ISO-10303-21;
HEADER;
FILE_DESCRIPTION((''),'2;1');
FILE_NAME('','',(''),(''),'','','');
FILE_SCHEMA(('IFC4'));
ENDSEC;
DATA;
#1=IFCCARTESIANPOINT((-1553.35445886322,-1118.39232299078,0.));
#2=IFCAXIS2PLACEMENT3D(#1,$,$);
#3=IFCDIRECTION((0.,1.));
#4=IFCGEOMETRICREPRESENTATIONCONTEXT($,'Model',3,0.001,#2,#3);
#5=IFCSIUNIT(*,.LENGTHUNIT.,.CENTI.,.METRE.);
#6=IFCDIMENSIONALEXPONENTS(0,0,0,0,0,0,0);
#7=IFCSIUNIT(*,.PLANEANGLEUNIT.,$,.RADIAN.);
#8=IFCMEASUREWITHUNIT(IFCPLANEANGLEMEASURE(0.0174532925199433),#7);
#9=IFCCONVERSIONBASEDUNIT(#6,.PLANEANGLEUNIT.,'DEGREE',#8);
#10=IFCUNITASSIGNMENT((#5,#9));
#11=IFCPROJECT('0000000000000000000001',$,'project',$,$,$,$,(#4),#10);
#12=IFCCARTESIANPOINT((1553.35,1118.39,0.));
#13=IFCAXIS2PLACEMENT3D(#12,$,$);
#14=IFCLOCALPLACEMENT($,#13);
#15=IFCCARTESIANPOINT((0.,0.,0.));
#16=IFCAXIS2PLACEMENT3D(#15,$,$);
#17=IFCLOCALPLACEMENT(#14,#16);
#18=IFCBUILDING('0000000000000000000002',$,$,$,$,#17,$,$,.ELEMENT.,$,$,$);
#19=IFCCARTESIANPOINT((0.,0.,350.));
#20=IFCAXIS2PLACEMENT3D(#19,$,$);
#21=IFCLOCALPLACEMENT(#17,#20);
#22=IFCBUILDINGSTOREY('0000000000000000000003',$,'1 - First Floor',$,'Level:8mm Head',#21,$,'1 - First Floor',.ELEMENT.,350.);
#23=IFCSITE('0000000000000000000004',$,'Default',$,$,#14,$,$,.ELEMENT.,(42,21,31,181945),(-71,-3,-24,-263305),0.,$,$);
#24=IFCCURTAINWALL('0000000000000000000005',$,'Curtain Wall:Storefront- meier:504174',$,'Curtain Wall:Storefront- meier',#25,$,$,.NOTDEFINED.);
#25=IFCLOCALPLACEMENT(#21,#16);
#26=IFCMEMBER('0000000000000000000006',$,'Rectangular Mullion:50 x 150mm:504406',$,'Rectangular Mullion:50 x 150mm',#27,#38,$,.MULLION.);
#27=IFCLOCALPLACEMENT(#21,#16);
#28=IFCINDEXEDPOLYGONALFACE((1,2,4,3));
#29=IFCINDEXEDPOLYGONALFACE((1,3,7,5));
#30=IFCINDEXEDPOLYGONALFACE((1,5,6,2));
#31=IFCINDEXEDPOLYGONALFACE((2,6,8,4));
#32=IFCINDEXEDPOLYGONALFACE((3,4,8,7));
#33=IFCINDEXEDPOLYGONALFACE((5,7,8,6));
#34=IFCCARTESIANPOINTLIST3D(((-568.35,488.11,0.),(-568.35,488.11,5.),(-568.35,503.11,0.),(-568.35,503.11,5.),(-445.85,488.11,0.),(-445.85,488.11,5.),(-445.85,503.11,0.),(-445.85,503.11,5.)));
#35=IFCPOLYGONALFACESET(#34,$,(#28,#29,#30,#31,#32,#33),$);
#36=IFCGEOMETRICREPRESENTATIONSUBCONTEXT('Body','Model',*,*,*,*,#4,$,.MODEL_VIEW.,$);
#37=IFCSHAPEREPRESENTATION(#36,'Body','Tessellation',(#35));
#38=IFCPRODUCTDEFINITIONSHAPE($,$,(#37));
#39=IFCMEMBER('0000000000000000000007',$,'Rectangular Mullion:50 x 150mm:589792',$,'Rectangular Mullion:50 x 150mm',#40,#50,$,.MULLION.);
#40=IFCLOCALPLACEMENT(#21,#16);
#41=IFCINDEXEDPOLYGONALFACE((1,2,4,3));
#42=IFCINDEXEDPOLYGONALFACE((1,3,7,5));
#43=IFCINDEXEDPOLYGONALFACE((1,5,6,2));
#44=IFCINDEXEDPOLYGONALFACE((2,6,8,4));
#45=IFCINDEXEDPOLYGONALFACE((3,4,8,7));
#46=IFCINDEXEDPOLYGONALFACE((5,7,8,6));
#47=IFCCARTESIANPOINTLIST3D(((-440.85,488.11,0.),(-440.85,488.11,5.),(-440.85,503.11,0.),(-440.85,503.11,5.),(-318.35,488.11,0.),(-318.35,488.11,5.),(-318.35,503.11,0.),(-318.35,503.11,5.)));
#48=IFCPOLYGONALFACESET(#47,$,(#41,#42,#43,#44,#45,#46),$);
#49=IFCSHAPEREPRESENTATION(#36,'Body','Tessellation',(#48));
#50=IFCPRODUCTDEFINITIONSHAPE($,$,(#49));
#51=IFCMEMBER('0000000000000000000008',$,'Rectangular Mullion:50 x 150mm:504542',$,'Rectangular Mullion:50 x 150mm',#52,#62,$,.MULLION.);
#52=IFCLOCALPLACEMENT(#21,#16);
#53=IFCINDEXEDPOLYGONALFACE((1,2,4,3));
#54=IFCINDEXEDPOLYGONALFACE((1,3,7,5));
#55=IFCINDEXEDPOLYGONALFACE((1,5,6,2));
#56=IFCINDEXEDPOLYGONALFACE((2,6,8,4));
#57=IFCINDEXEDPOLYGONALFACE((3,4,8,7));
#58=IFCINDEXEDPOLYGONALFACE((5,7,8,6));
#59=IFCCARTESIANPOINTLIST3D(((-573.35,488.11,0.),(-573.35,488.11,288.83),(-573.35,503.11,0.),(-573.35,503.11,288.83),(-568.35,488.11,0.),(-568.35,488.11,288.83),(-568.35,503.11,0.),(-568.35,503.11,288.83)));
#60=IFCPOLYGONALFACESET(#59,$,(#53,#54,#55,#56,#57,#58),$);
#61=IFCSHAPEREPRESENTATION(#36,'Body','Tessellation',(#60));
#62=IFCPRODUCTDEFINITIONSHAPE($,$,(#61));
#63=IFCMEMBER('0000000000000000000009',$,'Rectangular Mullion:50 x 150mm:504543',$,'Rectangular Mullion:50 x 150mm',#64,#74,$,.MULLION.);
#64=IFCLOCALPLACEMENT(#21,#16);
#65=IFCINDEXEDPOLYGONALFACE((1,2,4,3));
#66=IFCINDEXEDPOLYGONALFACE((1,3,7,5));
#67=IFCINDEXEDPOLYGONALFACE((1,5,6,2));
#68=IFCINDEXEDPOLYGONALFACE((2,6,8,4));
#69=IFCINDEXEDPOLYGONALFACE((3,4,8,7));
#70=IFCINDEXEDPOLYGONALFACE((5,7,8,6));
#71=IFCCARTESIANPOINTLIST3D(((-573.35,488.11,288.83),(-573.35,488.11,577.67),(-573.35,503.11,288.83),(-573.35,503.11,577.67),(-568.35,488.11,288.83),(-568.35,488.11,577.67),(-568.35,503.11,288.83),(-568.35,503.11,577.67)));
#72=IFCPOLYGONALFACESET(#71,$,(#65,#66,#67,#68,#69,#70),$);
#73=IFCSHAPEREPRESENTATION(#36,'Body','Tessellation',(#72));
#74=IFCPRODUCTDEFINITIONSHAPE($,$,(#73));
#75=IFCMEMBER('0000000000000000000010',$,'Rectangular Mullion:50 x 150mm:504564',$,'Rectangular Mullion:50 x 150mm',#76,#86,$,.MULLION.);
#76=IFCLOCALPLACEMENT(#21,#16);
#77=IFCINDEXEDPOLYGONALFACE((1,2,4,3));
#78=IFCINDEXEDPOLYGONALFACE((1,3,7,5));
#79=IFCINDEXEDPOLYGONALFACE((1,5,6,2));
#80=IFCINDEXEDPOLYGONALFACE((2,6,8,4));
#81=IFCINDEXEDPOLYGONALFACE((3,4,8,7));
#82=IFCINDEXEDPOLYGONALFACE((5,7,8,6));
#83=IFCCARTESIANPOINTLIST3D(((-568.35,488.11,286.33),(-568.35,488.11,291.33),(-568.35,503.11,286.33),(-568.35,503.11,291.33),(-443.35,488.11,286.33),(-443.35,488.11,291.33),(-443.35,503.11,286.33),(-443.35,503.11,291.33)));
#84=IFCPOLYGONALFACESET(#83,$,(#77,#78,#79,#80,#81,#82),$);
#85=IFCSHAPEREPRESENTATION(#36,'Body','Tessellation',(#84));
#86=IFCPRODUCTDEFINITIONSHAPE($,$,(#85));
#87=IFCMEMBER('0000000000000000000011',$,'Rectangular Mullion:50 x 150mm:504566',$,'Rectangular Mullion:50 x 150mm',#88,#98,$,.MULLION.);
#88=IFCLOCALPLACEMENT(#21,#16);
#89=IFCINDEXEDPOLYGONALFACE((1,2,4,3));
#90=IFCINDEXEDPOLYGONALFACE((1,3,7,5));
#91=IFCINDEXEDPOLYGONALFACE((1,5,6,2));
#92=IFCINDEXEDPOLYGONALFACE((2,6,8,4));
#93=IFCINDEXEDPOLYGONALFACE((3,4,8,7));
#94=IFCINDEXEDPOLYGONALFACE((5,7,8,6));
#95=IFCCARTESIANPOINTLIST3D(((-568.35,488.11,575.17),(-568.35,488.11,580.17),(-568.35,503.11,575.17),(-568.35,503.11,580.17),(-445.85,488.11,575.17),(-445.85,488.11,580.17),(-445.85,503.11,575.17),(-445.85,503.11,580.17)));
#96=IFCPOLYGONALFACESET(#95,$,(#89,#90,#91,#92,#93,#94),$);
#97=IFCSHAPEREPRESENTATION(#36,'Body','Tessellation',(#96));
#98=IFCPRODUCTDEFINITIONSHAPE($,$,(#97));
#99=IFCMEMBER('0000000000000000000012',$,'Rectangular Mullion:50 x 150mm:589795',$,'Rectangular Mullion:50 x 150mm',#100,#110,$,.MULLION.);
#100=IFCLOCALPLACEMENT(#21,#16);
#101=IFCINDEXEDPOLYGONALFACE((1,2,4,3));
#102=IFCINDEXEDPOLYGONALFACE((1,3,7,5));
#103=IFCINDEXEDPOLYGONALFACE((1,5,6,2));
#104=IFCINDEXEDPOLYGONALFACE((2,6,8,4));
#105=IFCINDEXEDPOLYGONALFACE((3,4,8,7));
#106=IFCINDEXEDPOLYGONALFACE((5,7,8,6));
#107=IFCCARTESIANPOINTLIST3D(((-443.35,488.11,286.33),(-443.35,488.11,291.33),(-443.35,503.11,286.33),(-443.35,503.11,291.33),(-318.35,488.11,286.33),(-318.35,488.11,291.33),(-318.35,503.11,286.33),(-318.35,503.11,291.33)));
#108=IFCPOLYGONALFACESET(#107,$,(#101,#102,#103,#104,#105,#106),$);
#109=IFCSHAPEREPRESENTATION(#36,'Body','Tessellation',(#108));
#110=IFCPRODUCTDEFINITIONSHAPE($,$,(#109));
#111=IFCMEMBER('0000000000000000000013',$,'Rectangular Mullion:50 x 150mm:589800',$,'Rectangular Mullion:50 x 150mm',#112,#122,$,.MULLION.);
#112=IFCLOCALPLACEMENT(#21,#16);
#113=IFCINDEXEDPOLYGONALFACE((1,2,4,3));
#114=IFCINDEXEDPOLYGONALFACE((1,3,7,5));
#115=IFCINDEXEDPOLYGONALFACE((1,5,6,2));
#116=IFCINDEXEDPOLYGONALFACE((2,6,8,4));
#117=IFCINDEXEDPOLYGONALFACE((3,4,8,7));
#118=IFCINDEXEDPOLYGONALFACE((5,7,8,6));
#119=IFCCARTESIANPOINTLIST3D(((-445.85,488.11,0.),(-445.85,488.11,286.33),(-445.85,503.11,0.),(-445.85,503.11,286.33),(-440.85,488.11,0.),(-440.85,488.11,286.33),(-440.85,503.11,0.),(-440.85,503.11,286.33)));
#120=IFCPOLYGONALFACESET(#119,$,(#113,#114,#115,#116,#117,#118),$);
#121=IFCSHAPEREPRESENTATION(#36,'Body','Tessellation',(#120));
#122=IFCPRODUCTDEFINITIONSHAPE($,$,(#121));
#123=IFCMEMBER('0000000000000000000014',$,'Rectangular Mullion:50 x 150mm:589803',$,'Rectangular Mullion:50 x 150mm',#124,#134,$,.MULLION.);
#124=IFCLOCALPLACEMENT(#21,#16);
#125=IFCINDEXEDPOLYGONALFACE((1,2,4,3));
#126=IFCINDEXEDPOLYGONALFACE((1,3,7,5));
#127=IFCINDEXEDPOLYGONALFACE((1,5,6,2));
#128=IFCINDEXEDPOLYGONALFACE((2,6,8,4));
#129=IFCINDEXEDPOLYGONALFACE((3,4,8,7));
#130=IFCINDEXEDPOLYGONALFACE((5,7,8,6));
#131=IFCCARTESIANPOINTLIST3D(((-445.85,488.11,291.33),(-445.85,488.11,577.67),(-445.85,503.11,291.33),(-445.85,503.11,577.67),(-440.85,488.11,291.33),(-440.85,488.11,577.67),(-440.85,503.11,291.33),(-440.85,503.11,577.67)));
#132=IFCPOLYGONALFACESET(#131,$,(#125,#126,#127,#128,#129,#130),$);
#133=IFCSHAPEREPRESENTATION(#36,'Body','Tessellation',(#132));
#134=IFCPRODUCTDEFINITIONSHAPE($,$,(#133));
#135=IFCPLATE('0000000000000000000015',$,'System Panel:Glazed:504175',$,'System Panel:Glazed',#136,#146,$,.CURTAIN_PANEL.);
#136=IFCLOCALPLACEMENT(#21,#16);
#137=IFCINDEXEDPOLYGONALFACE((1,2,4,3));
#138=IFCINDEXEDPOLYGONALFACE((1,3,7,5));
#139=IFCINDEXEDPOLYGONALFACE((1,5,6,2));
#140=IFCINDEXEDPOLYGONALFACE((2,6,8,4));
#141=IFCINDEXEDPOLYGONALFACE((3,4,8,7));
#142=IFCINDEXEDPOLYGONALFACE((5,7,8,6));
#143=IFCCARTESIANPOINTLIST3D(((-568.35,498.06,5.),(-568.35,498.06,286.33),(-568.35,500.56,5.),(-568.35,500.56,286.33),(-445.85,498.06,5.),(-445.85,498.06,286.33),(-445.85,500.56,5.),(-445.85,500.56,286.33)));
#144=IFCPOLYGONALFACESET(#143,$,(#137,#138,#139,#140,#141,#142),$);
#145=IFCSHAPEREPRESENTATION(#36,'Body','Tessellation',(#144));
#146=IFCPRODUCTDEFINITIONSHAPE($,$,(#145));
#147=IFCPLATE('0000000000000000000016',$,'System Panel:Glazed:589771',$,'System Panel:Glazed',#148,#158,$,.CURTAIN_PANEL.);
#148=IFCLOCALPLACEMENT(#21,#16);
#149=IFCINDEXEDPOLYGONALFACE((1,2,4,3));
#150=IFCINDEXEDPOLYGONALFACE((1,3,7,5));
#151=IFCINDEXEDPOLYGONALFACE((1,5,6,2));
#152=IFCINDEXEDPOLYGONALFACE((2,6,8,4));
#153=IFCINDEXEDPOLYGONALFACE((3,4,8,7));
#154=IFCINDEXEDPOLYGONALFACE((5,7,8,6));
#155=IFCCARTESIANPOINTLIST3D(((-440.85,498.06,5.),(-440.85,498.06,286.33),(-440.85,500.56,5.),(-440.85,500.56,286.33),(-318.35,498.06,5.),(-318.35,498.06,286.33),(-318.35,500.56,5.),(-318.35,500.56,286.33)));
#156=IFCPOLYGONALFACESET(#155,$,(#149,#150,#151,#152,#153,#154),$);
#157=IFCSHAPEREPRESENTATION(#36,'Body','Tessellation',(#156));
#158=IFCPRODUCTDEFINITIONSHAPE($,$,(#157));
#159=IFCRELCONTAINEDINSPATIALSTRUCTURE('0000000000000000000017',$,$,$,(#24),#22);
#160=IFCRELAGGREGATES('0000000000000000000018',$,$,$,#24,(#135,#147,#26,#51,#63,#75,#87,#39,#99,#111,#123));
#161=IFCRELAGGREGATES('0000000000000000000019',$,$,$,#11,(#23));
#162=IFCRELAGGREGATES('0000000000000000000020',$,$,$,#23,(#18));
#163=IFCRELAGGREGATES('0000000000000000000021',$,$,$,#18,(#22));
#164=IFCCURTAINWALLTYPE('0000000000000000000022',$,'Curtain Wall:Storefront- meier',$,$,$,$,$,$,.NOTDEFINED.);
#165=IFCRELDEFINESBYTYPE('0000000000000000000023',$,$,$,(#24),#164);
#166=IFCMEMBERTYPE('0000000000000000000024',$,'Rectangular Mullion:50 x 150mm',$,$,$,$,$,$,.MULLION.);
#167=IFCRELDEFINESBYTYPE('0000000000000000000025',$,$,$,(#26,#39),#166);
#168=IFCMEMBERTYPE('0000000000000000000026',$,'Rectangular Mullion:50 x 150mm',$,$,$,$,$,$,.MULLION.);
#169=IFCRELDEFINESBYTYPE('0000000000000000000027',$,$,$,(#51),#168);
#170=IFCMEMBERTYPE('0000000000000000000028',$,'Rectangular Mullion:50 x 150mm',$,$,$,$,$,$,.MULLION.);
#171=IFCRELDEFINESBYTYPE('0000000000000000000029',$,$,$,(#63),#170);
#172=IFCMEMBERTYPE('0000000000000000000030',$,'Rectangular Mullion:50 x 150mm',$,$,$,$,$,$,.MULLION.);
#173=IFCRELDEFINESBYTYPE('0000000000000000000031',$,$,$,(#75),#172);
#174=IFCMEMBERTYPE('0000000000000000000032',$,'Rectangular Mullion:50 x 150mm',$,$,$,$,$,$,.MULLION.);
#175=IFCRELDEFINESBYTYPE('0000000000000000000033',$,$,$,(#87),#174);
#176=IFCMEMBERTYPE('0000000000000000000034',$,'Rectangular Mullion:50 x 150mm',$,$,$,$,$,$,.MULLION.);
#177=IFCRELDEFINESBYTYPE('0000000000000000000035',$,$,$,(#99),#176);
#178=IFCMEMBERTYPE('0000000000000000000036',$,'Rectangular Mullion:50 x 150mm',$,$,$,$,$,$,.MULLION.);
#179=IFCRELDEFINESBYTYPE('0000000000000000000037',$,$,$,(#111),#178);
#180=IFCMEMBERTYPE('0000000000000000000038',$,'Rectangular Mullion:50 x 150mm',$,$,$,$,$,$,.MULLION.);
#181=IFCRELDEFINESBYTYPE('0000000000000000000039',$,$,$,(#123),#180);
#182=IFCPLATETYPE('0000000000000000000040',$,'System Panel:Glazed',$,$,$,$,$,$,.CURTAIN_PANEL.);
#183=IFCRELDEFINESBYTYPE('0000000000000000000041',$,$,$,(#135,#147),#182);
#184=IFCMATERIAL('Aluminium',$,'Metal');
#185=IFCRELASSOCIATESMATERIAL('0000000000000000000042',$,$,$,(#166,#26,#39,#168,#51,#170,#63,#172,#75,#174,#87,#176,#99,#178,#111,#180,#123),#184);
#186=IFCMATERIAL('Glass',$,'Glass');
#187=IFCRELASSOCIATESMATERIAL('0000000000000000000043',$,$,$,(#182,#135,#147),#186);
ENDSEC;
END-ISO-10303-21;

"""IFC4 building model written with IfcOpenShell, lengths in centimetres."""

from ifc_helpers import new_model, entity, si_unit, converted_unit, direction, frame, origin, place, context, subcontext, project, spatial, indexed_curve, outline, extrude, source, transform, mapped, material, type_object, type_shapes, element, aggregate, save


model = new_model("IFC4")

# Units and contexts
model_context = context("Model", 3, precision=0.001, world=frame((-1553.35445886322, -1118.39232299078, 0.0)), true_north=direction((0.0, 1.0)))
body_context = subcontext(model_context, "Body", "Model", "MODEL_VIEW")
ifc_project = project(units=[si_unit("LENGTHUNIT", "METRE", prefix="CENTI"), converted_unit("PLANEANGLEUNIT", "DEGREE", entity("IfcPlaneAngleMeasure", 0.0174532925199433), si_unit("PLANEANGLEUNIT", "RADIAN"), dimensions=[0, 0, 0, 0, 0, 0, 0])], contexts=[model_context])

# Site, building, storey
site_placement = place(None, frame((1553.35, 1118.39, 0.0)))
site = spatial("IfcSite", under=ifc_project, at=site_placement, Name="Default", CompositionType="ELEMENT", RefLatitude=(42, 21, 31, 181945), RefLongitude=(-71, -3, -24, -263305), RefElevation=0.0)
building_placement = place(site_placement, origin())
building = spatial("IfcBuilding", under=site, at=building_placement, CompositionType="ELEMENT")
storey_placement = place(building_placement, frame((0.0, 0.0, 350.0)))
storey = spatial("IfcBuildingStorey", under=building, at=storey_placement, Name="1 - First Floor", ObjectType="Level:8mm Head", LongName="1 - First Floor", CompositionType="ELEMENT", Elevation=350.0)

# Curtain wall, members, plates
curtain_wall_type = type_object("IfcCurtainWallType", Name="Curtain Wall:Storefront- meier", PredefinedType="NOTDEFINED")
curtain_wall_placement = place(storey_placement, frame((0.0, 0.0, -350.0)))
curtain_wall = element("IfcCurtainWall", 1, at=curtain_wall_placement, inside=storey, type_object=curtain_wall_type, Name="Curtain Wall:Storefront- meier:504174", ObjectType="Curtain Wall:Storefront- meier", PredefinedType="NOTDEFINED")
ifc_material_1 = material(Name="Aluminium", Category="Metal")
member_type_1 = type_object("IfcMemberType", Name="Rectangular Mullion:50 x 150mm", PredefinedType="MULLION", material=ifc_material_1)
shared_shape_1 = source(origin(), body_context, "Body", "SweptSolid", [
    extrude(outline(indexed_curve([(-2.5, -7.5), (2.5, -7.5), (2.5, 7.5), (-2.5, 7.5), (-2.5, -7.5)], self_intersect=False)), frame((-2.5, 0.0, -122.5), z_axis=(0.0, 0.0, 1.0), x_axis=(-1.0, 0.0, 0.0)), (0.0, 0.0, 1.0), 122.5),
])
type_shapes(member_type_1, [shared_shape_1])
member_1_placement = place(curtain_wall_placement, frame((-568.35, 495.61, 350.0), z_axis=(-1.0, 0.0, 0.0), x_axis=(0.0, 0.0, -1.0)))
member_1 = element("IfcMember", 2, at=member_1_placement, type_object=member_type_1, material=ifc_material_1, Name="Rectangular Mullion:50 x 150mm:504406", ObjectType="Rectangular Mullion:50 x 150mm", PredefinedType="MULLION", context=body_context, shape_type="MappedRepresentation", body=[
    mapped(shared_shape_1, transform((0.0, 0.0, 0.0), scale=1.0)),
])
member_2_placement = place(curtain_wall_placement, frame((-440.85, 495.61, 350.0), z_axis=(-1.0, 0.0, 0.0), x_axis=(0.0, 0.0, -1.0)))
member_2 = element("IfcMember", 3, at=member_2_placement, type_object=member_type_1, material=ifc_material_1, Name="Rectangular Mullion:50 x 150mm:589792", ObjectType="Rectangular Mullion:50 x 150mm", PredefinedType="MULLION", context=body_context, shape_type="MappedRepresentation", body=[
    mapped(shared_shape_1, transform((0.0, 0.0, 0.0), scale=1.0)),
])
member_type_2 = type_object("IfcMemberType", Name="Rectangular Mullion:50 x 150mm", PredefinedType="MULLION", material=ifc_material_1)
shared_shape_2 = source(origin(), body_context, "Body", "SweptSolid", [
    extrude(outline(indexed_curve([(-2.5, -7.5), (2.5, -7.5), (2.5, 7.5), (-2.5, 7.5), (-2.5, -7.5)], self_intersect=False)), frame((-2.5, 0.0, -288.83), z_axis=(0.0, 0.0, 1.0), x_axis=(-1.0, 0.0, 0.0)), (0.0, 0.0, 1.0), 288.83),
])
type_shapes(member_type_2, [shared_shape_2])
member_3_placement = place(curtain_wall_placement, frame((-573.35, 495.61, 638.83), z_axis=(0.0, 0.0, 1.0), x_axis=(-1.0, 0.0, 0.0)))
member_3 = element("IfcMember", 4, at=member_3_placement, type_object=member_type_2, material=ifc_material_1, Name="Rectangular Mullion:50 x 150mm:504542", ObjectType="Rectangular Mullion:50 x 150mm", PredefinedType="MULLION", context=body_context, shape_type="MappedRepresentation", body=[
    mapped(shared_shape_2, transform((0.0, 0.0, 0.0), scale=1.0)),
])
member_type_3 = type_object("IfcMemberType", Name="Rectangular Mullion:50 x 150mm", PredefinedType="MULLION", material=ifc_material_1)
shared_shape_3 = source(origin(), body_context, "Body", "SweptSolid", [
    extrude(outline(indexed_curve([(-2.5, -7.5), (2.5, -7.5), (2.5, 7.5), (-2.5, 7.5), (-2.5, -7.5)], self_intersect=False)), frame((-2.5, 0.0, -288.83), z_axis=(0.0, 0.0, 1.0), x_axis=(-1.0, 0.0, 0.0)), (0.0, 0.0, 1.0), 288.83),
])
type_shapes(member_type_3, [shared_shape_3])
member_4_placement = place(curtain_wall_placement, frame((-573.35, 495.61, 927.67), z_axis=(0.0, 0.0, 1.0), x_axis=(-1.0, 0.0, 0.0)))
member_4 = element("IfcMember", 5, at=member_4_placement, type_object=member_type_3, material=ifc_material_1, Name="Rectangular Mullion:50 x 150mm:504543", ObjectType="Rectangular Mullion:50 x 150mm", PredefinedType="MULLION", context=body_context, shape_type="MappedRepresentation", body=[
    mapped(shared_shape_3, transform((0.0, 0.0, 0.0), scale=1.0)),
])
member_type_4 = type_object("IfcMemberType", Name="Rectangular Mullion:50 x 150mm", PredefinedType="MULLION", material=ifc_material_1)
shared_shape_4 = source(origin(), body_context, "Body", "SweptSolid", [
    extrude(outline(indexed_curve([(-2.5, -7.5), (2.5, -7.5), (2.5, 7.5), (-2.5, 7.5), (-2.5, -7.5)], self_intersect=False)), frame((0.0, 0.0, -125.0), z_axis=(0.0, 0.0, 1.0), x_axis=(-1.0, 0.0, 0.0)), (0.0, 0.0, 1.0), 125.0),
])
type_shapes(member_type_4, [shared_shape_4])
member_5_placement = place(curtain_wall_placement, frame((-443.35, 495.61, 638.83), z_axis=(1.0, 0.0, 0.0), x_axis=(0.0, 0.0, 1.0)))
member_5 = element("IfcMember", 6, at=member_5_placement, type_object=member_type_4, material=ifc_material_1, Name="Rectangular Mullion:50 x 150mm:504564", ObjectType="Rectangular Mullion:50 x 150mm", PredefinedType="MULLION", context=body_context, shape_type="MappedRepresentation", body=[
    mapped(shared_shape_4, transform((0.0, 0.0, 0.0), scale=1.0)),
])
member_type_5 = type_object("IfcMemberType", Name="Rectangular Mullion:50 x 150mm", PredefinedType="MULLION", material=ifc_material_1)
shared_shape_5 = source(origin(), body_context, "Body", "SweptSolid", [
    extrude(outline(indexed_curve([(-2.5, -7.5), (2.5, -7.5), (2.5, 7.5), (-2.5, 7.5), (-2.5, -7.5)], self_intersect=False)), frame((0.0, 0.0, -122.5), z_axis=(0.0, 0.0, 1.0), x_axis=(-1.0, 0.0, 0.0)), (0.0, 0.0, 1.0), 122.5),
])
type_shapes(member_type_5, [shared_shape_5])
member_6_placement = place(curtain_wall_placement, frame((-445.85, 495.61, 927.67), z_axis=(1.0, 0.0, 0.0), x_axis=(0.0, 0.0, 1.0)))
member_6 = element("IfcMember", 7, at=member_6_placement, type_object=member_type_5, material=ifc_material_1, Name="Rectangular Mullion:50 x 150mm:504566", ObjectType="Rectangular Mullion:50 x 150mm", PredefinedType="MULLION", context=body_context, shape_type="MappedRepresentation", body=[
    mapped(shared_shape_5, transform((0.0, 0.0, 0.0), scale=1.0)),
])
member_type_6 = type_object("IfcMemberType", Name="Rectangular Mullion:50 x 150mm", PredefinedType="MULLION", material=ifc_material_1)
shared_shape_6 = source(origin(), body_context, "Body", "SweptSolid", [
    extrude(outline(indexed_curve([(-2.5, -7.5), (2.5, -7.5), (2.5, 7.5), (-2.5, 7.5), (-2.5, -7.5)], self_intersect=False)), frame((0.0, 0.0, -125.0), z_axis=(0.0, 0.0, 1.0), x_axis=(-1.0, 0.0, 0.0)), (0.0, 0.0, 1.0), 125.0),
])
type_shapes(member_type_6, [shared_shape_6])
member_7_placement = place(curtain_wall_placement, frame((-318.35, 495.61, 638.83), z_axis=(1.0, 0.0, 0.0), x_axis=(0.0, 0.0, 1.0)))
member_7 = element("IfcMember", 8, at=member_7_placement, type_object=member_type_6, material=ifc_material_1, Name="Rectangular Mullion:50 x 150mm:589795", ObjectType="Rectangular Mullion:50 x 150mm", PredefinedType="MULLION", context=body_context, shape_type="MappedRepresentation", body=[
    mapped(shared_shape_6, transform((0.0, 0.0, 0.0), scale=1.0)),
])
member_type_7 = type_object("IfcMemberType", Name="Rectangular Mullion:50 x 150mm", PredefinedType="MULLION", material=ifc_material_1)
shared_shape_7 = source(origin(), body_context, "Body", "SweptSolid", [
    extrude(outline(indexed_curve([(-2.5, -7.5), (2.5, -7.5), (2.5, 7.5), (-2.5, 7.5), (-2.5, -7.5)], self_intersect=False)), frame((0.0, 0.0, -286.33), z_axis=(0.0, 0.0, 1.0), x_axis=(-1.0, 0.0, 0.0)), (0.0, 0.0, 1.0), 286.33),
])
type_shapes(member_type_7, [shared_shape_7])
member_8_placement = place(curtain_wall_placement, frame((-443.35, 495.61, 350.0), z_axis=(0.0, 0.0, -1.0), x_axis=(1.0, 0.0, 0.0)))
member_8 = element("IfcMember", 9, at=member_8_placement, type_object=member_type_7, material=ifc_material_1, Name="Rectangular Mullion:50 x 150mm:589800", ObjectType="Rectangular Mullion:50 x 150mm", PredefinedType="MULLION", context=body_context, shape_type="MappedRepresentation", body=[
    mapped(shared_shape_7, transform((0.0, 0.0, 0.0), scale=1.0)),
])
member_type_8 = type_object("IfcMemberType", Name="Rectangular Mullion:50 x 150mm", PredefinedType="MULLION", material=ifc_material_1)
shared_shape_8 = source(origin(), body_context, "Body", "SweptSolid", [
    extrude(outline(indexed_curve([(-2.5, -7.5), (2.5, -7.5), (2.5, 7.5), (-2.5, 7.5), (-2.5, -7.5)], self_intersect=False)), frame((0.0, 0.0, -286.33), z_axis=(0.0, 0.0, 1.0), x_axis=(-1.0, 0.0, 0.0)), (0.0, 0.0, 1.0), 286.33),
])
type_shapes(member_type_8, [shared_shape_8])
member_9_placement = place(curtain_wall_placement, frame((-443.35, 495.61, 641.33), z_axis=(0.0, 0.0, -1.0), x_axis=(1.0, 0.0, 0.0)))
member_9 = element("IfcMember", 10, at=member_9_placement, type_object=member_type_8, material=ifc_material_1, Name="Rectangular Mullion:50 x 150mm:589803", ObjectType="Rectangular Mullion:50 x 150mm", PredefinedType="MULLION", context=body_context, shape_type="MappedRepresentation", body=[
    mapped(shared_shape_8, transform((0.0, 0.0, 0.0), scale=1.0)),
])
ifc_material_2 = material(Name="Glass", Category="Glass")
plate_type_1 = type_object("IfcPlateType", Name="System Panel:Glazed", PredefinedType="CURTAIN_PANEL", material=ifc_material_2)
shared_shape_9 = source(origin(), body_context, "Body", "SweptSolid", [
    extrude(outline(indexed_curve([(-1.25, -61.25), (1.25, -61.25), (1.25, 61.25), (-1.25, 61.25), (-1.25, -61.25)], self_intersect=False)), frame((0.0, 3.7, 0.0), z_axis=(0.0, 0.0, 1.0), x_axis=(0.0, 1.0, 0.0)), (0.0, 0.0, 1.0), 281.33),
])
type_shapes(plate_type_1, [shared_shape_9])
plate_1_placement = place(curtain_wall_placement, frame((-507.1, 495.61, 355.0)))
plate_1 = element("IfcPlate", 11, at=plate_1_placement, type_object=plate_type_1, material=ifc_material_2, Name="System Panel:Glazed:504175", ObjectType="System Panel:Glazed", PredefinedType="CURTAIN_PANEL", context=body_context, shape_type="MappedRepresentation", body=[
    mapped(shared_shape_9, transform((0.0, 0.0, 0.0), scale=1.0)),
])
plate_2_placement = place(curtain_wall_placement, frame((-379.6, 495.61, 355.0)))
plate_2 = element("IfcPlate", 12, at=plate_2_placement, type_object=plate_type_1, material=ifc_material_2, Name="System Panel:Glazed:589771", ObjectType="System Panel:Glazed", PredefinedType="CURTAIN_PANEL", context=body_context, shape_type="MappedRepresentation", body=[
    mapped(shared_shape_9, transform((0.0, 0.0, 0.0), scale=1.0)),
])
aggregate(curtain_wall, [plate_1, plate_2, member_1, member_3, member_4, member_5, member_6, member_2, member_7, member_8, member_9])

save(model, "model.ifc")
